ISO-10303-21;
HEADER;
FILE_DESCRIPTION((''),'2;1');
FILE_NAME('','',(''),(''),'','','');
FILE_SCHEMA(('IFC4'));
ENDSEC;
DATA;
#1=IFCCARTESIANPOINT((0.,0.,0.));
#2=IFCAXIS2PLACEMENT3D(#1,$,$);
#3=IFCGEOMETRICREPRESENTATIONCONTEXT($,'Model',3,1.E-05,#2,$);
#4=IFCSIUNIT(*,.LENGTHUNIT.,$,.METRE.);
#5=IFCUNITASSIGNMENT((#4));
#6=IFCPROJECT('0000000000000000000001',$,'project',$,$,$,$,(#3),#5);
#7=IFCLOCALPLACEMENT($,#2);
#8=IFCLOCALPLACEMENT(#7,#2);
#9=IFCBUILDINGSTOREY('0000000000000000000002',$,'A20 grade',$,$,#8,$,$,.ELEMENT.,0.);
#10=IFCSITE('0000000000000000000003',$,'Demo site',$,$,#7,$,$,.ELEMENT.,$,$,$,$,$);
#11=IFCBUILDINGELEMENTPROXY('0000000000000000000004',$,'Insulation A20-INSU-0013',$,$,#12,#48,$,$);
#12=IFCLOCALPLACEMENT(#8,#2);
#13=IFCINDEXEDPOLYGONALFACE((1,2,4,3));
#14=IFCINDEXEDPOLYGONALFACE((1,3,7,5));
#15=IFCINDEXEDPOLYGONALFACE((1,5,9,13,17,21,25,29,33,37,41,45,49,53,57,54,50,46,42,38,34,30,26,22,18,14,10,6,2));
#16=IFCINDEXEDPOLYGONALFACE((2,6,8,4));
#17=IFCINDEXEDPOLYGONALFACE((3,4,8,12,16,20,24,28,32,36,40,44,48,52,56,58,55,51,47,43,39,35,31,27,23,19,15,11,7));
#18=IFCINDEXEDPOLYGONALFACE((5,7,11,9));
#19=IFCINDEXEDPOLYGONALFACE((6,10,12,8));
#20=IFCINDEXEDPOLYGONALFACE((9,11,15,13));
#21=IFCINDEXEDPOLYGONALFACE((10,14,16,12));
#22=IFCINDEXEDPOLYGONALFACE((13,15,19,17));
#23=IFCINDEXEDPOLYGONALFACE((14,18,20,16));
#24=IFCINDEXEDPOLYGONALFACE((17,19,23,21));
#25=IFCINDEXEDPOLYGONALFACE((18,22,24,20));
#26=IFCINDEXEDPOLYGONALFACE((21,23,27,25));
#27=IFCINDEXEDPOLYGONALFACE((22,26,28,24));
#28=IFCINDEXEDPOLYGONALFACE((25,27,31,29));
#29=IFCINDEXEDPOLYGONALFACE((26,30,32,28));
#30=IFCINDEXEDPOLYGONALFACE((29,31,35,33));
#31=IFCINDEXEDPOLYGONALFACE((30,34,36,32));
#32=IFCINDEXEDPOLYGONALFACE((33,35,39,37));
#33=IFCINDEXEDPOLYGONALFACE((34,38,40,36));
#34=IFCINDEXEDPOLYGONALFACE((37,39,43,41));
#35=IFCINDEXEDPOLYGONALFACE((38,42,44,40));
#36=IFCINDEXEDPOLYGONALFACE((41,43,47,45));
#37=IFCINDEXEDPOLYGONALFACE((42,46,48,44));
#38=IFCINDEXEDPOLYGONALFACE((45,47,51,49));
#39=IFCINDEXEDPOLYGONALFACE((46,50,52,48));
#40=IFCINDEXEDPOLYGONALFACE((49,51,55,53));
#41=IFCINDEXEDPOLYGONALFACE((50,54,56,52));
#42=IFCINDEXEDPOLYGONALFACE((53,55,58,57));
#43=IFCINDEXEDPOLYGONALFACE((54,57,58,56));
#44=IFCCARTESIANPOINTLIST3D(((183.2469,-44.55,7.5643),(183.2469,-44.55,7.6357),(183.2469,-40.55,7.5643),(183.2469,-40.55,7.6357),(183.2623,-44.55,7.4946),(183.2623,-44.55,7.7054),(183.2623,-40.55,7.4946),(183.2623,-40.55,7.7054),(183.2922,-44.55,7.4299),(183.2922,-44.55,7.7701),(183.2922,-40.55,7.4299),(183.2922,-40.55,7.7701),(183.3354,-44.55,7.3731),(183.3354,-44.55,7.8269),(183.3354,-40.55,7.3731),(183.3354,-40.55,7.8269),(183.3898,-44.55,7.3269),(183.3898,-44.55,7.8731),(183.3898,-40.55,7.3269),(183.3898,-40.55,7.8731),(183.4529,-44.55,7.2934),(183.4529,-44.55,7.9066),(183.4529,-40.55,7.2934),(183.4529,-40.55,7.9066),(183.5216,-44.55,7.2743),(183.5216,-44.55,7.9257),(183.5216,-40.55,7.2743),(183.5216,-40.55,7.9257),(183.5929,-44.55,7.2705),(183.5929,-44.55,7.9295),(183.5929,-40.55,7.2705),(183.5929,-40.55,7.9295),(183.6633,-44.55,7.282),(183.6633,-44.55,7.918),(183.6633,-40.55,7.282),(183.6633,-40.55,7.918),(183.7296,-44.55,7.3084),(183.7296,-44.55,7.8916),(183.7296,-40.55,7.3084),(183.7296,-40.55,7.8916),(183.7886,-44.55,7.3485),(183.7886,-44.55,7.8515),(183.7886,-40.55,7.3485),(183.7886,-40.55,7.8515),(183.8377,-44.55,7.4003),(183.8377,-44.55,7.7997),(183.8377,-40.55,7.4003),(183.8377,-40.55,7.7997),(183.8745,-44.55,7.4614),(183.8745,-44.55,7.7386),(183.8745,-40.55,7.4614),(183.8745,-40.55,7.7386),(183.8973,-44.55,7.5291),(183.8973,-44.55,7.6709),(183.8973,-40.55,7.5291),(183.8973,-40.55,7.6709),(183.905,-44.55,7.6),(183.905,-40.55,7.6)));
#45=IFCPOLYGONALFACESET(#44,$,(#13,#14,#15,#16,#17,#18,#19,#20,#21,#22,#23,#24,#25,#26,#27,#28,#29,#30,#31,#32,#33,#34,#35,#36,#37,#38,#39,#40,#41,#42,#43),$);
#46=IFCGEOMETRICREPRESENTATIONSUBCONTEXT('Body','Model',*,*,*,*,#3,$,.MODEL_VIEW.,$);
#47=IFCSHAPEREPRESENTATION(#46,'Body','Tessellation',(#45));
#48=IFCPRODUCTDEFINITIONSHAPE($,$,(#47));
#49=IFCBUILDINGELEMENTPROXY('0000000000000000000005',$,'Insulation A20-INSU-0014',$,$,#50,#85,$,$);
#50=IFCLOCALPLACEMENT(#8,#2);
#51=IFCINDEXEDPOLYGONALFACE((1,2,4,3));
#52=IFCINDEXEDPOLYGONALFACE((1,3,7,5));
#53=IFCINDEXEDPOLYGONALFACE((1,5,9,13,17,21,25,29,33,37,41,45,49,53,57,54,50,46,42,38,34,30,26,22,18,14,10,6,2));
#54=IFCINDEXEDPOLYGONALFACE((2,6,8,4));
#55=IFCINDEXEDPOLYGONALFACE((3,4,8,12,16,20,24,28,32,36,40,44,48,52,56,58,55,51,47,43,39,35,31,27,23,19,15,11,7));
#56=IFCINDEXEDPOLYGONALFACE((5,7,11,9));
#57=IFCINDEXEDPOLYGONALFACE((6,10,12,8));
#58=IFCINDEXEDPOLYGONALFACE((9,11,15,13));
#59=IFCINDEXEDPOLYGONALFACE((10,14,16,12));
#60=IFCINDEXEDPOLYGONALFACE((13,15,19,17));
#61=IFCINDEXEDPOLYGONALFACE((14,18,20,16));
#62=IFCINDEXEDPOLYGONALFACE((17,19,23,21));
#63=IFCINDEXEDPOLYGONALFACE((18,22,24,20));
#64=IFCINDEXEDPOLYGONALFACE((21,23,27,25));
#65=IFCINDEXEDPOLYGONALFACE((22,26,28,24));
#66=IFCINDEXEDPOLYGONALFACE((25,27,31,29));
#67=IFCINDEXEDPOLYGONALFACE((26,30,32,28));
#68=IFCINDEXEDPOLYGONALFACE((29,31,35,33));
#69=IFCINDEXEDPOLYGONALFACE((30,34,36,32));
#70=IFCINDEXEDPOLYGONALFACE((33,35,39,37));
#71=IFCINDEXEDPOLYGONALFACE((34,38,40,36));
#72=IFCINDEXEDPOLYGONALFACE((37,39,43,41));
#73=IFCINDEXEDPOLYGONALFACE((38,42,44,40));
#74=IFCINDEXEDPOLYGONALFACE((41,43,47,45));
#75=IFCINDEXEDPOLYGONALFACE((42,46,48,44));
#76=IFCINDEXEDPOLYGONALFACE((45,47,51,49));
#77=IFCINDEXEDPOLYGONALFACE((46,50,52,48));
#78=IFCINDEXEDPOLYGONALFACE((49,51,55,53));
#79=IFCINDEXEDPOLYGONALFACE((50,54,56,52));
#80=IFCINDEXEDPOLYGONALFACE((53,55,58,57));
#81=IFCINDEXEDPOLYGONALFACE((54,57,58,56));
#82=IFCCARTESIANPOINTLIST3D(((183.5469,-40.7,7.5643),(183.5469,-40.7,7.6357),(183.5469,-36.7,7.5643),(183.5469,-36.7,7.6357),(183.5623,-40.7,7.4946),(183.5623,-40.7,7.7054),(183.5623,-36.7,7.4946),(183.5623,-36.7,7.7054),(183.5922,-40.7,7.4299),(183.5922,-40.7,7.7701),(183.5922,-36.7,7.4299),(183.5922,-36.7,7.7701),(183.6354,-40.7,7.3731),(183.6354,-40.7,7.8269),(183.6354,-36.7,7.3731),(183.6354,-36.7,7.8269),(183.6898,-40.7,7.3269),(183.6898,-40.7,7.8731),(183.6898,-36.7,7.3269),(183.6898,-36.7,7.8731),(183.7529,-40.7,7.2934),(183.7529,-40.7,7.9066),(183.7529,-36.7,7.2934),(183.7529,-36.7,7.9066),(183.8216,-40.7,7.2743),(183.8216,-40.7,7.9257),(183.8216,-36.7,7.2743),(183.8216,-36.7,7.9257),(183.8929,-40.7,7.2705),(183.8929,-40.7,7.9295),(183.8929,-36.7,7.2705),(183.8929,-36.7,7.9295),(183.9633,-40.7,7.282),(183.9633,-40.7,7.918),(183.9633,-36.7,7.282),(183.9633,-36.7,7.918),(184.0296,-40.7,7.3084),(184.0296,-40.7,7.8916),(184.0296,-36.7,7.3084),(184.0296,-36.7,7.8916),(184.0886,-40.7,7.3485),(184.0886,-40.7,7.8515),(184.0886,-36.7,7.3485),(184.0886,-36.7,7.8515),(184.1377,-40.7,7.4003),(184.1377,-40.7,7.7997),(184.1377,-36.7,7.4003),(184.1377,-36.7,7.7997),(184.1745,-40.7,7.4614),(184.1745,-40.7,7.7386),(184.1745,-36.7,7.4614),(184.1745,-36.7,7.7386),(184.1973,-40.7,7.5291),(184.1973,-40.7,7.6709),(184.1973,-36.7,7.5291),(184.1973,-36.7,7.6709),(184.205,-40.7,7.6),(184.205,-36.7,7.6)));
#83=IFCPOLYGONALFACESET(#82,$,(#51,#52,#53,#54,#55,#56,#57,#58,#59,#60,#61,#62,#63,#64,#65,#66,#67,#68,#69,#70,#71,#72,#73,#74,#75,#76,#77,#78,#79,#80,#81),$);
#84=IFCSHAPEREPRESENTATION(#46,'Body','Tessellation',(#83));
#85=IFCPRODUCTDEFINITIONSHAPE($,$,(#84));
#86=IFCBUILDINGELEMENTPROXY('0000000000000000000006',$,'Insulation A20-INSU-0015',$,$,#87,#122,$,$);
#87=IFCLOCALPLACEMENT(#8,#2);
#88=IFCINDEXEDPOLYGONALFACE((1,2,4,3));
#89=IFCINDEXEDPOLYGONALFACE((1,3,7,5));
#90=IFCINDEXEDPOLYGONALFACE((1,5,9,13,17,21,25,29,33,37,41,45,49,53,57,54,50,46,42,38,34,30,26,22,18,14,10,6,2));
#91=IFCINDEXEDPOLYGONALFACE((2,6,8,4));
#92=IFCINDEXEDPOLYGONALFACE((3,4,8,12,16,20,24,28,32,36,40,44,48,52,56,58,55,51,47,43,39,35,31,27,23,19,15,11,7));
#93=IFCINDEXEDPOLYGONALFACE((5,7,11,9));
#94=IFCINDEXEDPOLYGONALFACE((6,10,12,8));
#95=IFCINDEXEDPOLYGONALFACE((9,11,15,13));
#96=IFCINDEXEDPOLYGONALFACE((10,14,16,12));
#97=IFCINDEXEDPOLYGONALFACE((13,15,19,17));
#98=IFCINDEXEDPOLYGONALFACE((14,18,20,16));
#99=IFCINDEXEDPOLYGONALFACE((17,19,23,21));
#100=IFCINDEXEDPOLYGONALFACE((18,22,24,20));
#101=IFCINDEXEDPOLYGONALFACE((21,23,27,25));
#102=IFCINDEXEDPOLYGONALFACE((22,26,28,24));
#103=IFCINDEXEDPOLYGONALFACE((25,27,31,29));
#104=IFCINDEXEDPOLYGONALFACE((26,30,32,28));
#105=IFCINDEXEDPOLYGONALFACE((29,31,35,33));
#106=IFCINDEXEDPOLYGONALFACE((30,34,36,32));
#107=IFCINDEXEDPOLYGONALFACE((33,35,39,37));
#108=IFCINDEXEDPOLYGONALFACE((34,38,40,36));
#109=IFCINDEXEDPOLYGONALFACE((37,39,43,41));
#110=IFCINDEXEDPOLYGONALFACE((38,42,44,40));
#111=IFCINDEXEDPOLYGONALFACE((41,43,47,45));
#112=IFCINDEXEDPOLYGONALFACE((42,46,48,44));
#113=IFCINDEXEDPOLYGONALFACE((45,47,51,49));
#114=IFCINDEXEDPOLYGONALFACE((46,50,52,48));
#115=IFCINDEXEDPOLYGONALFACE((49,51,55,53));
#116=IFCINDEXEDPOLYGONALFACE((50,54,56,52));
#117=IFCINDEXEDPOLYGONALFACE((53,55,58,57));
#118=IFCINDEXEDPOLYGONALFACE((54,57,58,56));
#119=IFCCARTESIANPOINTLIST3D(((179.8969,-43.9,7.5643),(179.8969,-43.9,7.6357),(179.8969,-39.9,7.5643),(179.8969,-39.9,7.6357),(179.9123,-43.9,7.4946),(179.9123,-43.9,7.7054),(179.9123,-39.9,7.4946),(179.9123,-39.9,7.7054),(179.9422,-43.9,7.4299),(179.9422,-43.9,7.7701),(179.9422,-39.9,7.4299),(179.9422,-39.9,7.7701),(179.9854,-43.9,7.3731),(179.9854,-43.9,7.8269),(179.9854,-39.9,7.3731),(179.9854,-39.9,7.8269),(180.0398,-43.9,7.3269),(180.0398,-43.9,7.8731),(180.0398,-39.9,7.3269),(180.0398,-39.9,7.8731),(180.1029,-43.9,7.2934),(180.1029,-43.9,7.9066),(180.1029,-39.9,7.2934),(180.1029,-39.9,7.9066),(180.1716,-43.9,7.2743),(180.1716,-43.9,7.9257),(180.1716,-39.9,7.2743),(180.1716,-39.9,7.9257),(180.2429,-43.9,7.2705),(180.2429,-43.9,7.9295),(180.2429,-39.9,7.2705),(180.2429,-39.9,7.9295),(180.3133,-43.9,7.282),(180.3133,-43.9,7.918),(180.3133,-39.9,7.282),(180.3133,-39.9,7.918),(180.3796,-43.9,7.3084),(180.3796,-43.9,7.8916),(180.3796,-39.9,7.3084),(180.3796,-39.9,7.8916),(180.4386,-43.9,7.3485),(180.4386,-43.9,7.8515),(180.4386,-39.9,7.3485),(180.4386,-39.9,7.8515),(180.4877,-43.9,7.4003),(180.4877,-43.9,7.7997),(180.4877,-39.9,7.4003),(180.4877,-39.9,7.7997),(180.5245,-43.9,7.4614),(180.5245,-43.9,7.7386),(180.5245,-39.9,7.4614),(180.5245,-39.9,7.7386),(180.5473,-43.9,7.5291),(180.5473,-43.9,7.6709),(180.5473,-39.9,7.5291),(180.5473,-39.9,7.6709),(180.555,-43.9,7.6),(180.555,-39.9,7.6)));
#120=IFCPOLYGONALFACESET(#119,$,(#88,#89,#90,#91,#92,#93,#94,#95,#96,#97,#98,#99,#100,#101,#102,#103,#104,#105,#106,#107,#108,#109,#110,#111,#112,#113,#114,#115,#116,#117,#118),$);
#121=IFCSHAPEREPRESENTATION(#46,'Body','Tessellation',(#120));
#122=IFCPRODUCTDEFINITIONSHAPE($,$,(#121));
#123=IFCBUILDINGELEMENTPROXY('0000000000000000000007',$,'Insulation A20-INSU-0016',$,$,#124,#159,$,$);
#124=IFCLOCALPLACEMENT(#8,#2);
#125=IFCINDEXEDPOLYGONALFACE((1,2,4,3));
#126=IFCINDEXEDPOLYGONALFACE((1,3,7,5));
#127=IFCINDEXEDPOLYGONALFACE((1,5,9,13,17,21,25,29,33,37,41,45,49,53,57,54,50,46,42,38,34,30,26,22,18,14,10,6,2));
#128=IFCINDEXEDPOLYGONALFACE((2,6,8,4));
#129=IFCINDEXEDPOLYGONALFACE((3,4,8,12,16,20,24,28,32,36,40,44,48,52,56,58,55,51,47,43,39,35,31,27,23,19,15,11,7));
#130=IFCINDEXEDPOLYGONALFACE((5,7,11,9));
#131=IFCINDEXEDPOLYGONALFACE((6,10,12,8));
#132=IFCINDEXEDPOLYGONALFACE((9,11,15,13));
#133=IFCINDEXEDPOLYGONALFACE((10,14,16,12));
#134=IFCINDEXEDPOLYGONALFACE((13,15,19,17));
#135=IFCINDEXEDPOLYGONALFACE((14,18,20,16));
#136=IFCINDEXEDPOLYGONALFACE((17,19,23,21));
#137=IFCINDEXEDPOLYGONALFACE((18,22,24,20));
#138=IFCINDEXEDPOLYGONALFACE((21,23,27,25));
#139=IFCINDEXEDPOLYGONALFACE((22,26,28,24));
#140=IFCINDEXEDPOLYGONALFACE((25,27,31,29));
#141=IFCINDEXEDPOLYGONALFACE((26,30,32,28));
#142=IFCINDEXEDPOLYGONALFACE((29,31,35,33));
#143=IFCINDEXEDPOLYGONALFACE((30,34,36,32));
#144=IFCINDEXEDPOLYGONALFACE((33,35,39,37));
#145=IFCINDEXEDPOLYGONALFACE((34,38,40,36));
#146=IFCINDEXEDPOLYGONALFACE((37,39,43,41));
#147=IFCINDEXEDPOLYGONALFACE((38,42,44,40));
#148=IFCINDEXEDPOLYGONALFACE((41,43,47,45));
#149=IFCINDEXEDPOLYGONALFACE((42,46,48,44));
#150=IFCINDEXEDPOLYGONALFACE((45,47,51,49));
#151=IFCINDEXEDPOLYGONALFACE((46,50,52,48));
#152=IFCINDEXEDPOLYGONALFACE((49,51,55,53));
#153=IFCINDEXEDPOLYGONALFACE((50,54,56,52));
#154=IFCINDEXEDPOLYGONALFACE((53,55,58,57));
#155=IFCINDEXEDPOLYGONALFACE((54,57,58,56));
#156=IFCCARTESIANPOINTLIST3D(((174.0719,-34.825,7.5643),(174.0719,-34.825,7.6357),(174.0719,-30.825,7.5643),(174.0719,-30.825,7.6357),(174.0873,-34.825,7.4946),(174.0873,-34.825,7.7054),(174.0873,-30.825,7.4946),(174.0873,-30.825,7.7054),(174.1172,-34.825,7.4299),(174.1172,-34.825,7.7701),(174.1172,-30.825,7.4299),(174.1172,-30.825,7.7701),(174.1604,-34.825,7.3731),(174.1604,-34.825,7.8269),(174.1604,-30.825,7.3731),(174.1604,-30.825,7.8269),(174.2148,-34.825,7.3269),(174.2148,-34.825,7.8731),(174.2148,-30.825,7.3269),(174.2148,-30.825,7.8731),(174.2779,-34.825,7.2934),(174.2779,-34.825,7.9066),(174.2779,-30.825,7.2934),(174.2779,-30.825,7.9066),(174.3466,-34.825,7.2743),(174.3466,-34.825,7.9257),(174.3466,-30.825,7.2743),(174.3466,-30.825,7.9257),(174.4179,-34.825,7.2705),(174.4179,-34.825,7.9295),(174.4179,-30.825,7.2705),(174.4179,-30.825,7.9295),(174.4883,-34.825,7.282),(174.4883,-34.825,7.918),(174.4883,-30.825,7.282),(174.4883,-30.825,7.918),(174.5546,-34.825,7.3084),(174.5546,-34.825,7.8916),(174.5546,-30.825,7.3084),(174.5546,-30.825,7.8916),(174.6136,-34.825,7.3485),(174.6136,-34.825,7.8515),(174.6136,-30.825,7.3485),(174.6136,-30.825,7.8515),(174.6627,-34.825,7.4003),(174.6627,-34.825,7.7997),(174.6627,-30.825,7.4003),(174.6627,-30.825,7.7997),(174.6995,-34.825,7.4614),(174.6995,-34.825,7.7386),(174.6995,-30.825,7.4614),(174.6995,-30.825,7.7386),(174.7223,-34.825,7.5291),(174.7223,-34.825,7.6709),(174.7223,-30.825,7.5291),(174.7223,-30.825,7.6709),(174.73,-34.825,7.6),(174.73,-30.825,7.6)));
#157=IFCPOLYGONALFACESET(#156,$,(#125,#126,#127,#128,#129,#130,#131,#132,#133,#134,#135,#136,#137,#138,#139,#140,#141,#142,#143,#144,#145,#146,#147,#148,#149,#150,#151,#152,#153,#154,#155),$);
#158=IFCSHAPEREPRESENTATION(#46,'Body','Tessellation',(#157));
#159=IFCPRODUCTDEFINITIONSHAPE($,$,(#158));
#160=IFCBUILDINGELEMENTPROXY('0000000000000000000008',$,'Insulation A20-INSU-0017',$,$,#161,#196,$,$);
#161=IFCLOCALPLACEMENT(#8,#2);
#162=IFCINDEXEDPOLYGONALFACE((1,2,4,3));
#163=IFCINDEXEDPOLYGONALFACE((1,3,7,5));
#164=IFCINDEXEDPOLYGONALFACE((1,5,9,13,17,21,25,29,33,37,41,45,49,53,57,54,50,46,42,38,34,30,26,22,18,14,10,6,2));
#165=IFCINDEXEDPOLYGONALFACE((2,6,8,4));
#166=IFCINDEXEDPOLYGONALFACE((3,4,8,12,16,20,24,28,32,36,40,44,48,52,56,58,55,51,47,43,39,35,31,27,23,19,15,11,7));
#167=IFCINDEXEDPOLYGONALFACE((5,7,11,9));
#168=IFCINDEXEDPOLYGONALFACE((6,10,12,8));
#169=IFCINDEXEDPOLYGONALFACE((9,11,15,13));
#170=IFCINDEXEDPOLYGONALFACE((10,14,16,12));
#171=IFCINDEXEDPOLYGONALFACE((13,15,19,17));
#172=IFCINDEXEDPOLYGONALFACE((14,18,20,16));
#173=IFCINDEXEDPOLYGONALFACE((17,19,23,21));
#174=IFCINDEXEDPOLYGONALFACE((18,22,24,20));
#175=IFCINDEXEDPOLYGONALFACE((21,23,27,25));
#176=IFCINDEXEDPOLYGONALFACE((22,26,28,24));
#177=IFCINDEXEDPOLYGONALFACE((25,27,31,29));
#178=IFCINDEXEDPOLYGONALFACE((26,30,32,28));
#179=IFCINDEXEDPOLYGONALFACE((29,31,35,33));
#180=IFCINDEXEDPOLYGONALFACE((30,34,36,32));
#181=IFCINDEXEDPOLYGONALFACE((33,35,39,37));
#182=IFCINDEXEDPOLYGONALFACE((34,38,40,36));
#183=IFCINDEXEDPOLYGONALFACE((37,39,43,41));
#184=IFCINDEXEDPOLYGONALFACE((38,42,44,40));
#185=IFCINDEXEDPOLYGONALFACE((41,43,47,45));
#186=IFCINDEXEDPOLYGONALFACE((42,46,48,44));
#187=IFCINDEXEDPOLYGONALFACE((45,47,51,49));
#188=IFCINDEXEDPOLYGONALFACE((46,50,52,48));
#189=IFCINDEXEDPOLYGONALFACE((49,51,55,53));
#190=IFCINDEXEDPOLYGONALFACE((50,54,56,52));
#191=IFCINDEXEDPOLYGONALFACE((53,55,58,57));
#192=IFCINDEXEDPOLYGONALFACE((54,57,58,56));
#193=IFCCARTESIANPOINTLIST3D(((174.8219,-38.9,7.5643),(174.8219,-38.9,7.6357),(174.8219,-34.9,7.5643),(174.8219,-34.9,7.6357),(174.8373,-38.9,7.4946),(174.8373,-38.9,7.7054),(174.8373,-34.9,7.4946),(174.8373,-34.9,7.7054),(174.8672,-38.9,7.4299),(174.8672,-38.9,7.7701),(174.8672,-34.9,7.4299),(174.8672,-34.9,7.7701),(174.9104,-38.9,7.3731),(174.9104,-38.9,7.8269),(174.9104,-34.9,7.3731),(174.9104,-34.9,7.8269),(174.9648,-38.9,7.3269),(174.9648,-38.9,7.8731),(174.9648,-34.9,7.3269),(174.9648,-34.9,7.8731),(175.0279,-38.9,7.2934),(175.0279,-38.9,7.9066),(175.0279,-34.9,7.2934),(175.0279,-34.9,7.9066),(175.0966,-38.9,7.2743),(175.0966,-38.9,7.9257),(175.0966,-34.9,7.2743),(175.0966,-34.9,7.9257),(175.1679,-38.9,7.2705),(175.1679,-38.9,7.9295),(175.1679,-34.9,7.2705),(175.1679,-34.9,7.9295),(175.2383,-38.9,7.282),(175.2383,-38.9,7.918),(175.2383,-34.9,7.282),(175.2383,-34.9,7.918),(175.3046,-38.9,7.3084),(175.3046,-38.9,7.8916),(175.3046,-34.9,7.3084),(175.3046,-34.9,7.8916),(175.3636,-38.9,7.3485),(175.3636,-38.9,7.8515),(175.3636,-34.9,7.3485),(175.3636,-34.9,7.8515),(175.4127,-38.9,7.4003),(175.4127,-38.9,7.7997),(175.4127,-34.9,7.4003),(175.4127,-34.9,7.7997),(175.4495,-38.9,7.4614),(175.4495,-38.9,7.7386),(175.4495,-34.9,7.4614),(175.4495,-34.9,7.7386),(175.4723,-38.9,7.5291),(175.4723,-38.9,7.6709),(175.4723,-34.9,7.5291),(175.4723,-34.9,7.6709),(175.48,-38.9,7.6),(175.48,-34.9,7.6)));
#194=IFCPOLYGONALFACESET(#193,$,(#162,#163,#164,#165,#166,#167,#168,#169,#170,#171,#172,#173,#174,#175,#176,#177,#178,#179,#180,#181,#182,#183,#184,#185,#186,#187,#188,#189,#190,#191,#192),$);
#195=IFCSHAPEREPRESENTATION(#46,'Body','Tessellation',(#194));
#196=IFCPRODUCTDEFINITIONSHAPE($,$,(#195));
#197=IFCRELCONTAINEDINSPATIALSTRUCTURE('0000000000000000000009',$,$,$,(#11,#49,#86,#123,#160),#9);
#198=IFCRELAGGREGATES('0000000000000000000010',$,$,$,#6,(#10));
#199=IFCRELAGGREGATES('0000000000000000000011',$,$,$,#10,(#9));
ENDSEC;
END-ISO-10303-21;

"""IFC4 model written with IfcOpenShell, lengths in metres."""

from ifc_helpers import new_model, si_unit, frame, origin, place, context, subcontext, project, spatial, circle, extrude, element, save


model = new_model("IFC4")

# Units and contexts
model_context = context("Model", 3, precision=1e-05, world=origin())
body_context = subcontext(model_context, "Body", "Model", "MODEL_VIEW")
ifc_project = project(units=[si_unit("LENGTHUNIT", "METRE")], contexts=[model_context])

# Site, storey
site_placement = place(None, origin())
site = spatial("IfcSite", under=ifc_project, at=site_placement, Name="Demo site", CompositionType="ELEMENT")
storey_placement = place(site_placement, origin())
storey = spatial("IfcBuildingStorey", under=site, at=storey_placement, Name="A20 grade", CompositionType="ELEMENT", Elevation=0.0)

# Building element proxies
for number, where, name in (
    (1, (183.575, -44.55, 7.6), "Insulation A20-INSU-0013"),
    (2, (183.875, -40.7, 7.6), "Insulation A20-INSU-0014"),
    (3, (180.225, -43.9, 7.6), "Insulation A20-INSU-0015"),
    (4, (174.4, -34.825, 7.6), "Insulation A20-INSU-0016"),
    (5, (175.15, -38.9, 7.6), "Insulation A20-INSU-0017"),
):
    element("IfcBuildingElementProxy", number, at=place(storey_placement, frame(where)), inside=storey, Name=name, context=body_context, shape_type="SweptSolid", body=[
        extrude(circle(Radius=0.33), frame((0.0, 0.0, 0.0), z_axis=(0.0, 1.0, 0.0), x_axis=(1.0, 0.0, 0.0)), (0.0, 0.0, 1.0), 4.0),
    ])

save(model, "model.ifc")
